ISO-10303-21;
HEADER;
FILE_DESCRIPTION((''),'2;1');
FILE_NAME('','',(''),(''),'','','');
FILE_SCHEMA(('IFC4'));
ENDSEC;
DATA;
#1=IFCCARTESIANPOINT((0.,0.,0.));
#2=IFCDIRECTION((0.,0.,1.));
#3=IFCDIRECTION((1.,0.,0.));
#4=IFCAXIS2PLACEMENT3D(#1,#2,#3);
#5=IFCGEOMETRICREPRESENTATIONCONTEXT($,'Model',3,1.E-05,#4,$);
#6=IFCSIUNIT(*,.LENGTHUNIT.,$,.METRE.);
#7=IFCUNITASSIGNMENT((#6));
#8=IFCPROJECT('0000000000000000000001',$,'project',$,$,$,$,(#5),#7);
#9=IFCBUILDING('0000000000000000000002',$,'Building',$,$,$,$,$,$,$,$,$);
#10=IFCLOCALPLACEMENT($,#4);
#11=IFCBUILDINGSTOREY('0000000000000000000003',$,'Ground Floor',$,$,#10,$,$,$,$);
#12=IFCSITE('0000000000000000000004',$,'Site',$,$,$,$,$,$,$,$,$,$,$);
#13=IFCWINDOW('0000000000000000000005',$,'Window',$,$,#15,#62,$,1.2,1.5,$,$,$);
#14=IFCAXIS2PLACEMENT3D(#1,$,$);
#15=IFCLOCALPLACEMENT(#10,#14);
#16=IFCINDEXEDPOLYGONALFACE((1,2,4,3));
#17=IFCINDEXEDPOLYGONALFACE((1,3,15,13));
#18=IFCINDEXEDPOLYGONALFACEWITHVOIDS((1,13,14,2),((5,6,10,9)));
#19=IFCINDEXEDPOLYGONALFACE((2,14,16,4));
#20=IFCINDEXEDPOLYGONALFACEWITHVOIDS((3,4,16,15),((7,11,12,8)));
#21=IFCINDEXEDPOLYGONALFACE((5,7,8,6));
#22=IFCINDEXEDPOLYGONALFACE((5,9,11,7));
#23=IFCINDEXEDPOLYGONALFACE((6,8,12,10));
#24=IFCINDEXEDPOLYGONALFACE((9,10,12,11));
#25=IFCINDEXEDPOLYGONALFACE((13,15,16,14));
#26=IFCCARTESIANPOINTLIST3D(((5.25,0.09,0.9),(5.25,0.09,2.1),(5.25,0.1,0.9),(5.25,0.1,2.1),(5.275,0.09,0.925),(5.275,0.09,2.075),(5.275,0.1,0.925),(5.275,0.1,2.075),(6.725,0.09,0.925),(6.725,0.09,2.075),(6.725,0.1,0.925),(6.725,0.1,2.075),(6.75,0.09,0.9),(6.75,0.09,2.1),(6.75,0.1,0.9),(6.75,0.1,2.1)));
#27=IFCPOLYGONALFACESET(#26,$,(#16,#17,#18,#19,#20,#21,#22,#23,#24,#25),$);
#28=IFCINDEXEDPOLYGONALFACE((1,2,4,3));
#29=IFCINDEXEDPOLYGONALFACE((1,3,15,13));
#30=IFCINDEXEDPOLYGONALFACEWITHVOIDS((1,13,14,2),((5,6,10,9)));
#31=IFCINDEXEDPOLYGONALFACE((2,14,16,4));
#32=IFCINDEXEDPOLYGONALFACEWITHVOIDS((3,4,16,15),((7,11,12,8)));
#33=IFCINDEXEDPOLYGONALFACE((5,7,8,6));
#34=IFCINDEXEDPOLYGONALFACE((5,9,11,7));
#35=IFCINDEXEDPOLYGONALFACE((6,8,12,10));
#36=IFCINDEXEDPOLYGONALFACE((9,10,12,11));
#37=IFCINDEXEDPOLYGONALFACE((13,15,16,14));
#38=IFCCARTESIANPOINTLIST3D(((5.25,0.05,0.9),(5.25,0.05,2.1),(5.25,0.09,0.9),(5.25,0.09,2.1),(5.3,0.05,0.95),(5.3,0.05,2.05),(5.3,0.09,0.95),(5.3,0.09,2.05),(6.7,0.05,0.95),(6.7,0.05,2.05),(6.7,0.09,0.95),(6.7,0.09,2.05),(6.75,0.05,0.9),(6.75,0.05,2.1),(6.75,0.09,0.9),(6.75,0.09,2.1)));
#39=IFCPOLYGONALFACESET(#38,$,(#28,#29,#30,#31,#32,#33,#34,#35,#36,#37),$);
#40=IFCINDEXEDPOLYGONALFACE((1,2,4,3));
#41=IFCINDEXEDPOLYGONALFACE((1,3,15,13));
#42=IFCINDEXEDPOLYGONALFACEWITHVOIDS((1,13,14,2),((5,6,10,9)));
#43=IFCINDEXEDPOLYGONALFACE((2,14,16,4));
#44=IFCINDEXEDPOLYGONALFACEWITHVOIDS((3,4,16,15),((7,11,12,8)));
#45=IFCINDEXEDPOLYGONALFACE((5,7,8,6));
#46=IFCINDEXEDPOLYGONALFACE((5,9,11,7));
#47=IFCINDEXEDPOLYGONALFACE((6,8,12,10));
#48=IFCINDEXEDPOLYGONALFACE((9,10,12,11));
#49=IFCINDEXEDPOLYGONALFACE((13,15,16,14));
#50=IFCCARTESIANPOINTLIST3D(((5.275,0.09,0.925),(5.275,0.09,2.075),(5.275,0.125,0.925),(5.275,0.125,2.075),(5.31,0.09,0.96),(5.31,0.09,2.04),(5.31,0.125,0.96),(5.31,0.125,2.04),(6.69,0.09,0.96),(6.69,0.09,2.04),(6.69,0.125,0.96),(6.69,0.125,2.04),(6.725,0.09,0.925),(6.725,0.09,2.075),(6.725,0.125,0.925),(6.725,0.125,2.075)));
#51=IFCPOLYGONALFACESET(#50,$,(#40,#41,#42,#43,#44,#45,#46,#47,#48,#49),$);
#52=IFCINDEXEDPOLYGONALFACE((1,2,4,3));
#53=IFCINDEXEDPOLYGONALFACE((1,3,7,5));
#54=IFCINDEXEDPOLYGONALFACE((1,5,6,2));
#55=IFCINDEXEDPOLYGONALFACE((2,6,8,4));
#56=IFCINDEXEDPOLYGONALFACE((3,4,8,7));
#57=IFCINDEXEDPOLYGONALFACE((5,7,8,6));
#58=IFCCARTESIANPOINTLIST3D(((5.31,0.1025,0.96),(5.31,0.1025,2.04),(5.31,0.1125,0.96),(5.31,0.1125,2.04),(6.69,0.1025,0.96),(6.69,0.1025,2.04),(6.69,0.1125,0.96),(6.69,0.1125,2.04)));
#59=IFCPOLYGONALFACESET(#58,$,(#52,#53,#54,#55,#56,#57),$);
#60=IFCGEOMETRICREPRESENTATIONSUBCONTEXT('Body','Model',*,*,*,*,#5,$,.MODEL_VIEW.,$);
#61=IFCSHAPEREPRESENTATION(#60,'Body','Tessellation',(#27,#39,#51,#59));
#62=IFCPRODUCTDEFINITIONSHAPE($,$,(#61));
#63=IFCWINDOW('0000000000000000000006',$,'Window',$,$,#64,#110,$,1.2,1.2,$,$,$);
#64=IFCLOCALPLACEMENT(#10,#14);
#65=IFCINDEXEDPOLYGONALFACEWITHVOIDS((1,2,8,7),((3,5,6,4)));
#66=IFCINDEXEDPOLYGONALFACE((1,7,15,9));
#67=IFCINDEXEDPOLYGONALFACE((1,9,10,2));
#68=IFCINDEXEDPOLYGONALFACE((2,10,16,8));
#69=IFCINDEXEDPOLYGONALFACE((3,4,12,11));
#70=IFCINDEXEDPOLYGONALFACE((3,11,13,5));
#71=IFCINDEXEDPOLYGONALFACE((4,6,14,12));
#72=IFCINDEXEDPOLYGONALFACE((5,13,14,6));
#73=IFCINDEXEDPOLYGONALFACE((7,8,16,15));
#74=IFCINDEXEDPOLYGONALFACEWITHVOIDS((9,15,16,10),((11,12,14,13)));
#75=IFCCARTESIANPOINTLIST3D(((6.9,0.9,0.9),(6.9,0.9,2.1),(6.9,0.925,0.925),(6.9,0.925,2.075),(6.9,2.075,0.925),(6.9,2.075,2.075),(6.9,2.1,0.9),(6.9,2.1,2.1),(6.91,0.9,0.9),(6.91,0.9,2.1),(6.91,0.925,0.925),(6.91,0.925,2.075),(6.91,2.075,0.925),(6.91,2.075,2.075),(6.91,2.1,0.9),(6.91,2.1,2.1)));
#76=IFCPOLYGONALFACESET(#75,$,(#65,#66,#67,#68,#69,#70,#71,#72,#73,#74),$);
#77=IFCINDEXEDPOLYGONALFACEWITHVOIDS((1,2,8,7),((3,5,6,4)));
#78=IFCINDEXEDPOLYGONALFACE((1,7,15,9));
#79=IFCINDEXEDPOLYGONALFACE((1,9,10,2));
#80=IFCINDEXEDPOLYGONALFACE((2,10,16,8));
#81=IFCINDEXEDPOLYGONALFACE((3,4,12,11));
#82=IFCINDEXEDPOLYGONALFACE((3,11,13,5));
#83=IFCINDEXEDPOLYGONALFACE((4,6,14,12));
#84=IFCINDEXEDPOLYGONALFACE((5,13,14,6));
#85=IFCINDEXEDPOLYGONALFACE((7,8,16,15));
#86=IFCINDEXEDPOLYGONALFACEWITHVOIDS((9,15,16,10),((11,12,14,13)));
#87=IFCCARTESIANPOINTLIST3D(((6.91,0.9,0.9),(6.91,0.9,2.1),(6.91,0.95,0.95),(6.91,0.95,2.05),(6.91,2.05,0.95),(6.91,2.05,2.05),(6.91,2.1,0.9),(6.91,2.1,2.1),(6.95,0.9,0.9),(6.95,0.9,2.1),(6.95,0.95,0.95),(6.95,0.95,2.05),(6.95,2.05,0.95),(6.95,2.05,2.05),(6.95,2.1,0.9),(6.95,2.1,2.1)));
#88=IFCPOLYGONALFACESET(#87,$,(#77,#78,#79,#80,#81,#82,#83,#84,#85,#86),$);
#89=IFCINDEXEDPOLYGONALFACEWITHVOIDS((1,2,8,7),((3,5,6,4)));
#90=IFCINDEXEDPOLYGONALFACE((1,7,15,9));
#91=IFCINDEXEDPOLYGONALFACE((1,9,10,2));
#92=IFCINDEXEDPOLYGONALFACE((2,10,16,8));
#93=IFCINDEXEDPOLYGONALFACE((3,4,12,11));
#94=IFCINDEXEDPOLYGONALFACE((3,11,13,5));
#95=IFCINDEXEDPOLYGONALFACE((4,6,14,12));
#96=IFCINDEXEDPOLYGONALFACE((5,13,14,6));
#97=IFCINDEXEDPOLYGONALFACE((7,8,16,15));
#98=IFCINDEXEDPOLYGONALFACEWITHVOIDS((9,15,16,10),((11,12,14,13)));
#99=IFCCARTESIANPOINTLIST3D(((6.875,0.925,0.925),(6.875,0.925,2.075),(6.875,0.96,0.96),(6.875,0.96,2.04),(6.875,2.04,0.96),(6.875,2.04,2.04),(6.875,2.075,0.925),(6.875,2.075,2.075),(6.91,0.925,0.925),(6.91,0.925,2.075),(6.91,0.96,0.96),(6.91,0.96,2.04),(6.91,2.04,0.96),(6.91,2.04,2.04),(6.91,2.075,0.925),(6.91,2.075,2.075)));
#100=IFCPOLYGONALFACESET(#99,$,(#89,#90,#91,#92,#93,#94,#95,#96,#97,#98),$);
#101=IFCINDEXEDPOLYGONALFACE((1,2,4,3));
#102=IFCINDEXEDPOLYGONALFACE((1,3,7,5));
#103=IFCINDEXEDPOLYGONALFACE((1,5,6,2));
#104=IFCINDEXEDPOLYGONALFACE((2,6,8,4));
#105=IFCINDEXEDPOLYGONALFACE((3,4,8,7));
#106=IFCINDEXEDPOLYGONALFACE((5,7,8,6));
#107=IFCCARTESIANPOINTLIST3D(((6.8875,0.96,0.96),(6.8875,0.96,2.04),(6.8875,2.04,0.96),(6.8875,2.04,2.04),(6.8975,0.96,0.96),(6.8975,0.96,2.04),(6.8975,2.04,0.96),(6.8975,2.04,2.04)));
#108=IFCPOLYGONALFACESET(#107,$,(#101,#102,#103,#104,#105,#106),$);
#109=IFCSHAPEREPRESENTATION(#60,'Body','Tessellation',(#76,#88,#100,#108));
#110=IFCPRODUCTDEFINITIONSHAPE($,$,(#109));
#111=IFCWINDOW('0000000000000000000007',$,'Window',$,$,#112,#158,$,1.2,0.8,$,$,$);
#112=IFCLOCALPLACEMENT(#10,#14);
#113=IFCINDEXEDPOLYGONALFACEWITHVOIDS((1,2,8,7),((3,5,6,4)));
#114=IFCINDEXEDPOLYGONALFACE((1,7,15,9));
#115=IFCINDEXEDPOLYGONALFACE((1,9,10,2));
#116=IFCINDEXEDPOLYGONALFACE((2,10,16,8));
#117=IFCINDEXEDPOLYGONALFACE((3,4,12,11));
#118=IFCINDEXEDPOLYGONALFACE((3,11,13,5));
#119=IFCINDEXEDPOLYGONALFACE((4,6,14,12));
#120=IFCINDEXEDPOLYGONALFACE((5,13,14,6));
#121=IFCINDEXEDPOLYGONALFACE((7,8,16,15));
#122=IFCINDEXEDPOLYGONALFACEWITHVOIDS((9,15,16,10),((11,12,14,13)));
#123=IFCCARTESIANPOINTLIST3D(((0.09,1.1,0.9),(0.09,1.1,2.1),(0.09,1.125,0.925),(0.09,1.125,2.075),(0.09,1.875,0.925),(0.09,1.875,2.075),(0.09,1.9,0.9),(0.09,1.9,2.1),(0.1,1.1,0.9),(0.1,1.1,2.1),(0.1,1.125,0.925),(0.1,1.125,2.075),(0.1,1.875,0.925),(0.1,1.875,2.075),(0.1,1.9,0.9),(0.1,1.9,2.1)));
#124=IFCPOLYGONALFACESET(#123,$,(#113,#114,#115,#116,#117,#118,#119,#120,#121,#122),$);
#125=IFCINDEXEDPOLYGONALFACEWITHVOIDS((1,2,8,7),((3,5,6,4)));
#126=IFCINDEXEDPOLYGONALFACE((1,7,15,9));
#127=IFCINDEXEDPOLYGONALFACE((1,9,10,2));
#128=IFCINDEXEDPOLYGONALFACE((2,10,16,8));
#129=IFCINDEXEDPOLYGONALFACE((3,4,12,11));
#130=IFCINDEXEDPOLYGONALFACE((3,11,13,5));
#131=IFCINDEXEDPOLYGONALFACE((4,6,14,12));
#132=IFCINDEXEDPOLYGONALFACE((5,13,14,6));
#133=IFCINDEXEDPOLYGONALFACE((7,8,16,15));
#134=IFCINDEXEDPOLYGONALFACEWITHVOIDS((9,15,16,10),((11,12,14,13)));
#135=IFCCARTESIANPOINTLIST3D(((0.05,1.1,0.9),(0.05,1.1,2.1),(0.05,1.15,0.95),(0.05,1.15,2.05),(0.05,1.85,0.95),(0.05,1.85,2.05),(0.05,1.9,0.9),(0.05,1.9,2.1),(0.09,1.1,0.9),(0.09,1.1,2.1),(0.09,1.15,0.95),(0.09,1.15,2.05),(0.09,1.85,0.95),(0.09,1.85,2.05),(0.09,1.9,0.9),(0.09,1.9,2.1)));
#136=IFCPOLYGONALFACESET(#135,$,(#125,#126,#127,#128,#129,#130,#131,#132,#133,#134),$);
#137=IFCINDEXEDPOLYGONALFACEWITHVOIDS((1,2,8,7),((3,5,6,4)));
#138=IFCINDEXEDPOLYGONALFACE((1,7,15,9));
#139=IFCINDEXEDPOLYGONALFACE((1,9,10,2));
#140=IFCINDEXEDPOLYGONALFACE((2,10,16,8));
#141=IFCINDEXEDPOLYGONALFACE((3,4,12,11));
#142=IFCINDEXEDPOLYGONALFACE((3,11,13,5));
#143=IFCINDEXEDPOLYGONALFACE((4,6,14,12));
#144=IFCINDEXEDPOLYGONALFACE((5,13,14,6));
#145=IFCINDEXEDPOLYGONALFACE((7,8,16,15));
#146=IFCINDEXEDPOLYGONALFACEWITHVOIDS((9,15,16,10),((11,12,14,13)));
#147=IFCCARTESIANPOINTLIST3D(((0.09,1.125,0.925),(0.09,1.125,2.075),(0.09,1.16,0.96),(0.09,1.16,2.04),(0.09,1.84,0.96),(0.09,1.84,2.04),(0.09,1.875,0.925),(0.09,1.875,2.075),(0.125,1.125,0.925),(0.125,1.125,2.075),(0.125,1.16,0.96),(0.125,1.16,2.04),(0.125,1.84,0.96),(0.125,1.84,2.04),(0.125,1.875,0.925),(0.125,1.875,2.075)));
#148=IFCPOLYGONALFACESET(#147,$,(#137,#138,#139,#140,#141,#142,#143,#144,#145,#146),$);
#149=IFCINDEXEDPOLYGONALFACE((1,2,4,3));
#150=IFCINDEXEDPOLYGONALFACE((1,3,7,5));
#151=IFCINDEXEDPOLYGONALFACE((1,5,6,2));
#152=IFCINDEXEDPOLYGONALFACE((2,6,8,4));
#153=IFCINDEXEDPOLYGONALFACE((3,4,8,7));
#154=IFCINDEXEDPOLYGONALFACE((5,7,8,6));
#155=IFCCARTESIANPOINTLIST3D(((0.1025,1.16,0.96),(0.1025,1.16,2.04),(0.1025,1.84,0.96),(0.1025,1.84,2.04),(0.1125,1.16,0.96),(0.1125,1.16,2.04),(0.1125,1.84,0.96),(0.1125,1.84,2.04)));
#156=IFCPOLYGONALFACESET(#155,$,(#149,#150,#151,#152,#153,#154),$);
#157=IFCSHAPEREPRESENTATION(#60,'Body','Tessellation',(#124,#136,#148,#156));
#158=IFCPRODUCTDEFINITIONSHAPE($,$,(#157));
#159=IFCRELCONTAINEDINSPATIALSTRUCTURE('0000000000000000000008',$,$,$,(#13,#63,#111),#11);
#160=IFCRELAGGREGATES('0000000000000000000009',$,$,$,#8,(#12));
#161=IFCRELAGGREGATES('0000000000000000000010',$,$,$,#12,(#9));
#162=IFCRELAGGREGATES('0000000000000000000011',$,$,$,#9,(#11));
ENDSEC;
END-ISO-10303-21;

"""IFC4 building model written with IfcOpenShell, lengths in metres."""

from ifc_helpers import new_model, si_unit, frame, origin_with_axes, place, context, subcontext, project, spatial, line, indexed_curve, outline, extrude, element, save


model = new_model("IFC4")

# Units and contexts
model_context = context("Model", 3, precision=1e-05, world=origin_with_axes())
body_context = subcontext(model_context, "Body", "Model", "MODEL_VIEW")
ifc_project = project(units=[si_unit("LENGTHUNIT", "METRE")], contexts=[model_context])

# Site, building, storey
site = spatial("IfcSite", under=ifc_project, Name="Site")
building = spatial("IfcBuilding", under=site, Name="Building")
storey_placement = place(None, origin_with_axes())
storey = spatial("IfcBuildingStorey", under=building, at=storey_placement, Name="Ground Floor")

# Windows
window_1_placement = place(storey_placement, frame((5.25, 0.0, 0.9), z_axis=(0.0, 0.0, 1.0), x_axis=(1.0, 0.0, 0.0)))
element("IfcWindow", 1, at=window_1_placement, inside=storey, Name="Window", OverallHeight=1.2, OverallWidth=1.5, context=body_context, shape_type="SweptSolid", body=[
    extrude(outline(indexed_curve([(0.0, 0.0), (1.5, 0.0), (1.5, 1.2), (0.0, 1.2)], segments=[line(1, 2, 3, 4, 1)]), holes=[indexed_curve([(0.025, 0.025), (1.475, 0.025), (1.475, 1.175), (0.025, 1.175)], segments=[line(1, 2, 3, 4, 1)])]), frame((0.0, 0.09, 0.0), z_axis=(0.0, -1.0, 0.0), x_axis=(1.0, 0.0, 0.0)), (0.0, 0.0, -1.0), 0.01),
    extrude(outline(indexed_curve([(0.0, 0.0), (1.5, 0.0), (1.5, 1.2), (0.0, 1.2)], segments=[line(1, 2, 3, 4, 1)]), holes=[indexed_curve([(0.05, 0.05), (1.45, 0.05), (1.45, 1.15), (0.05, 1.15)], segments=[line(1, 2, 3, 4, 1)])]), frame((0.0, 0.05, 0.0), z_axis=(0.0, -1.0, 0.0), x_axis=(1.0, 0.0, 0.0)), (0.0, 0.0, -1.0), 0.04),
    extrude(outline(indexed_curve([(0.0, 0.0), (1.45, 0.0), (1.45, 1.15), (0.0, 1.15)], segments=[line(1, 2, 3, 4, 1)]), holes=[indexed_curve([(0.035, 0.035), (1.415, 0.035), (1.415, 1.115), (0.035, 1.115)], segments=[line(1, 2, 3, 4, 1)])]), frame((0.025, 0.09, 0.025), z_axis=(0.0, -1.0, 0.0), x_axis=(1.0, 0.0, 0.0)), (0.0, 0.0, -1.0), 0.035),
    extrude(outline(indexed_curve([(0.035, 0.035), (1.415, 0.035), (1.415, 1.115), (0.035, 1.115)], segments=[line(1, 2, 3, 4, 1)])), frame((0.025, 0.1025, 0.025), z_axis=(0.0, -1.0, 0.0), x_axis=(1.0, 0.0, 0.0)), (0.0, 0.0, -1.0), 0.01),
])
window_2_placement = place(storey_placement, frame((7.0, 0.9, 0.9), z_axis=(0.0, 0.0, 1.0), x_axis=(0.0, 1.0, 0.0)))
element("IfcWindow", 2, at=window_2_placement, inside=storey, Name="Window", OverallHeight=1.2, OverallWidth=1.2, context=body_context, shape_type="SweptSolid", body=[
    extrude(outline(indexed_curve([(0.0, 0.0), (1.2, 0.0), (1.2, 1.2), (0.0, 1.2)], segments=[line(1, 2, 3, 4, 1)]), holes=[indexed_curve([(0.025, 0.025), (1.175, 0.025), (1.175, 1.175), (0.025, 1.175)], segments=[line(1, 2, 3, 4, 1)])]), frame((0.0, 0.09, 0.0), z_axis=(0.0, -1.0, 0.0), x_axis=(1.0, 0.0, 0.0)), (0.0, 0.0, -1.0), 0.01),
    extrude(outline(indexed_curve([(0.0, 0.0), (1.2, 0.0), (1.2, 1.2), (0.0, 1.2)], segments=[line(1, 2, 3, 4, 1)]), holes=[indexed_curve([(0.05, 0.05), (1.15, 0.05), (1.15, 1.15), (0.05, 1.15)], segments=[line(1, 2, 3, 4, 1)])]), frame((0.0, 0.05, 0.0), z_axis=(0.0, -1.0, 0.0), x_axis=(1.0, 0.0, 0.0)), (0.0, 0.0, -1.0), 0.04),
    extrude(outline(indexed_curve([(0.0, 0.0), (1.15, 0.0), (1.15, 1.15), (0.0, 1.15)], segments=[line(1, 2, 3, 4, 1)]), holes=[indexed_curve([(0.035, 0.035), (1.115, 0.035), (1.115, 1.115), (0.035, 1.115)], segments=[line(1, 2, 3, 4, 1)])]), frame((0.025, 0.09, 0.025), z_axis=(0.0, -1.0, 0.0), x_axis=(1.0, 0.0, 0.0)), (0.0, 0.0, -1.0), 0.035),
    extrude(outline(indexed_curve([(0.035, 0.035), (1.115, 0.035), (1.115, 1.115), (0.035, 1.115)], segments=[line(1, 2, 3, 4, 1)])), frame((0.025, 0.1025, 0.025), z_axis=(0.0, -1.0, 0.0), x_axis=(1.0, 0.0, 0.0)), (0.0, 0.0, -1.0), 0.01),
])
window_3_placement = place(storey_placement, frame((0.0, 1.9, 0.9), z_axis=(0.0, 0.0, 1.0), x_axis=(0.0, -1.0, 0.0)))
element("IfcWindow", 3, at=window_3_placement, inside=storey, Name="Window", OverallHeight=1.2, OverallWidth=0.8, context=body_context, shape_type="SweptSolid", body=[
    extrude(outline(indexed_curve([(0.0, 0.0), (0.8, 0.0), (0.8, 1.2), (0.0, 1.2)], segments=[line(1, 2, 3, 4, 1)]), holes=[indexed_curve([(0.025, 0.025), (0.775, 0.025), (0.775, 1.175), (0.025, 1.175)], segments=[line(1, 2, 3, 4, 1)])]), frame((0.0, 0.09, 0.0), z_axis=(0.0, -1.0, 0.0), x_axis=(1.0, 0.0, 0.0)), (0.0, 0.0, -1.0), 0.01),
    extrude(outline(indexed_curve([(0.0, 0.0), (0.8, 0.0), (0.8, 1.2), (0.0, 1.2)], segments=[line(1, 2, 3, 4, 1)]), holes=[indexed_curve([(0.05, 0.05), (0.75, 0.05), (0.75, 1.15), (0.05, 1.15)], segments=[line(1, 2, 3, 4, 1)])]), frame((0.0, 0.05, 0.0), z_axis=(0.0, -1.0, 0.0), x_axis=(1.0, 0.0, 0.0)), (0.0, 0.0, -1.0), 0.04),
    extrude(outline(indexed_curve([(0.0, 0.0), (0.75, 0.0), (0.75, 1.15), (0.0, 1.15)], segments=[line(1, 2, 3, 4, 1)]), holes=[indexed_curve([(0.035, 0.035), (0.715, 0.035), (0.715, 1.115), (0.035, 1.115)], segments=[line(1, 2, 3, 4, 1)])]), frame((0.025, 0.09, 0.025), z_axis=(0.0, -1.0, 0.0), x_axis=(1.0, 0.0, 0.0)), (0.0, 0.0, -1.0), 0.035),
    extrude(outline(indexed_curve([(0.035, 0.035), (0.715, 0.035), (0.715, 1.115), (0.035, 1.115)], segments=[line(1, 2, 3, 4, 1)])), frame((0.025, 0.1025, 0.025), z_axis=(0.0, -1.0, 0.0), x_axis=(1.0, 0.0, 0.0)), (0.0, 0.0, -1.0), 0.01),
])

save(model, "model.ifc")
